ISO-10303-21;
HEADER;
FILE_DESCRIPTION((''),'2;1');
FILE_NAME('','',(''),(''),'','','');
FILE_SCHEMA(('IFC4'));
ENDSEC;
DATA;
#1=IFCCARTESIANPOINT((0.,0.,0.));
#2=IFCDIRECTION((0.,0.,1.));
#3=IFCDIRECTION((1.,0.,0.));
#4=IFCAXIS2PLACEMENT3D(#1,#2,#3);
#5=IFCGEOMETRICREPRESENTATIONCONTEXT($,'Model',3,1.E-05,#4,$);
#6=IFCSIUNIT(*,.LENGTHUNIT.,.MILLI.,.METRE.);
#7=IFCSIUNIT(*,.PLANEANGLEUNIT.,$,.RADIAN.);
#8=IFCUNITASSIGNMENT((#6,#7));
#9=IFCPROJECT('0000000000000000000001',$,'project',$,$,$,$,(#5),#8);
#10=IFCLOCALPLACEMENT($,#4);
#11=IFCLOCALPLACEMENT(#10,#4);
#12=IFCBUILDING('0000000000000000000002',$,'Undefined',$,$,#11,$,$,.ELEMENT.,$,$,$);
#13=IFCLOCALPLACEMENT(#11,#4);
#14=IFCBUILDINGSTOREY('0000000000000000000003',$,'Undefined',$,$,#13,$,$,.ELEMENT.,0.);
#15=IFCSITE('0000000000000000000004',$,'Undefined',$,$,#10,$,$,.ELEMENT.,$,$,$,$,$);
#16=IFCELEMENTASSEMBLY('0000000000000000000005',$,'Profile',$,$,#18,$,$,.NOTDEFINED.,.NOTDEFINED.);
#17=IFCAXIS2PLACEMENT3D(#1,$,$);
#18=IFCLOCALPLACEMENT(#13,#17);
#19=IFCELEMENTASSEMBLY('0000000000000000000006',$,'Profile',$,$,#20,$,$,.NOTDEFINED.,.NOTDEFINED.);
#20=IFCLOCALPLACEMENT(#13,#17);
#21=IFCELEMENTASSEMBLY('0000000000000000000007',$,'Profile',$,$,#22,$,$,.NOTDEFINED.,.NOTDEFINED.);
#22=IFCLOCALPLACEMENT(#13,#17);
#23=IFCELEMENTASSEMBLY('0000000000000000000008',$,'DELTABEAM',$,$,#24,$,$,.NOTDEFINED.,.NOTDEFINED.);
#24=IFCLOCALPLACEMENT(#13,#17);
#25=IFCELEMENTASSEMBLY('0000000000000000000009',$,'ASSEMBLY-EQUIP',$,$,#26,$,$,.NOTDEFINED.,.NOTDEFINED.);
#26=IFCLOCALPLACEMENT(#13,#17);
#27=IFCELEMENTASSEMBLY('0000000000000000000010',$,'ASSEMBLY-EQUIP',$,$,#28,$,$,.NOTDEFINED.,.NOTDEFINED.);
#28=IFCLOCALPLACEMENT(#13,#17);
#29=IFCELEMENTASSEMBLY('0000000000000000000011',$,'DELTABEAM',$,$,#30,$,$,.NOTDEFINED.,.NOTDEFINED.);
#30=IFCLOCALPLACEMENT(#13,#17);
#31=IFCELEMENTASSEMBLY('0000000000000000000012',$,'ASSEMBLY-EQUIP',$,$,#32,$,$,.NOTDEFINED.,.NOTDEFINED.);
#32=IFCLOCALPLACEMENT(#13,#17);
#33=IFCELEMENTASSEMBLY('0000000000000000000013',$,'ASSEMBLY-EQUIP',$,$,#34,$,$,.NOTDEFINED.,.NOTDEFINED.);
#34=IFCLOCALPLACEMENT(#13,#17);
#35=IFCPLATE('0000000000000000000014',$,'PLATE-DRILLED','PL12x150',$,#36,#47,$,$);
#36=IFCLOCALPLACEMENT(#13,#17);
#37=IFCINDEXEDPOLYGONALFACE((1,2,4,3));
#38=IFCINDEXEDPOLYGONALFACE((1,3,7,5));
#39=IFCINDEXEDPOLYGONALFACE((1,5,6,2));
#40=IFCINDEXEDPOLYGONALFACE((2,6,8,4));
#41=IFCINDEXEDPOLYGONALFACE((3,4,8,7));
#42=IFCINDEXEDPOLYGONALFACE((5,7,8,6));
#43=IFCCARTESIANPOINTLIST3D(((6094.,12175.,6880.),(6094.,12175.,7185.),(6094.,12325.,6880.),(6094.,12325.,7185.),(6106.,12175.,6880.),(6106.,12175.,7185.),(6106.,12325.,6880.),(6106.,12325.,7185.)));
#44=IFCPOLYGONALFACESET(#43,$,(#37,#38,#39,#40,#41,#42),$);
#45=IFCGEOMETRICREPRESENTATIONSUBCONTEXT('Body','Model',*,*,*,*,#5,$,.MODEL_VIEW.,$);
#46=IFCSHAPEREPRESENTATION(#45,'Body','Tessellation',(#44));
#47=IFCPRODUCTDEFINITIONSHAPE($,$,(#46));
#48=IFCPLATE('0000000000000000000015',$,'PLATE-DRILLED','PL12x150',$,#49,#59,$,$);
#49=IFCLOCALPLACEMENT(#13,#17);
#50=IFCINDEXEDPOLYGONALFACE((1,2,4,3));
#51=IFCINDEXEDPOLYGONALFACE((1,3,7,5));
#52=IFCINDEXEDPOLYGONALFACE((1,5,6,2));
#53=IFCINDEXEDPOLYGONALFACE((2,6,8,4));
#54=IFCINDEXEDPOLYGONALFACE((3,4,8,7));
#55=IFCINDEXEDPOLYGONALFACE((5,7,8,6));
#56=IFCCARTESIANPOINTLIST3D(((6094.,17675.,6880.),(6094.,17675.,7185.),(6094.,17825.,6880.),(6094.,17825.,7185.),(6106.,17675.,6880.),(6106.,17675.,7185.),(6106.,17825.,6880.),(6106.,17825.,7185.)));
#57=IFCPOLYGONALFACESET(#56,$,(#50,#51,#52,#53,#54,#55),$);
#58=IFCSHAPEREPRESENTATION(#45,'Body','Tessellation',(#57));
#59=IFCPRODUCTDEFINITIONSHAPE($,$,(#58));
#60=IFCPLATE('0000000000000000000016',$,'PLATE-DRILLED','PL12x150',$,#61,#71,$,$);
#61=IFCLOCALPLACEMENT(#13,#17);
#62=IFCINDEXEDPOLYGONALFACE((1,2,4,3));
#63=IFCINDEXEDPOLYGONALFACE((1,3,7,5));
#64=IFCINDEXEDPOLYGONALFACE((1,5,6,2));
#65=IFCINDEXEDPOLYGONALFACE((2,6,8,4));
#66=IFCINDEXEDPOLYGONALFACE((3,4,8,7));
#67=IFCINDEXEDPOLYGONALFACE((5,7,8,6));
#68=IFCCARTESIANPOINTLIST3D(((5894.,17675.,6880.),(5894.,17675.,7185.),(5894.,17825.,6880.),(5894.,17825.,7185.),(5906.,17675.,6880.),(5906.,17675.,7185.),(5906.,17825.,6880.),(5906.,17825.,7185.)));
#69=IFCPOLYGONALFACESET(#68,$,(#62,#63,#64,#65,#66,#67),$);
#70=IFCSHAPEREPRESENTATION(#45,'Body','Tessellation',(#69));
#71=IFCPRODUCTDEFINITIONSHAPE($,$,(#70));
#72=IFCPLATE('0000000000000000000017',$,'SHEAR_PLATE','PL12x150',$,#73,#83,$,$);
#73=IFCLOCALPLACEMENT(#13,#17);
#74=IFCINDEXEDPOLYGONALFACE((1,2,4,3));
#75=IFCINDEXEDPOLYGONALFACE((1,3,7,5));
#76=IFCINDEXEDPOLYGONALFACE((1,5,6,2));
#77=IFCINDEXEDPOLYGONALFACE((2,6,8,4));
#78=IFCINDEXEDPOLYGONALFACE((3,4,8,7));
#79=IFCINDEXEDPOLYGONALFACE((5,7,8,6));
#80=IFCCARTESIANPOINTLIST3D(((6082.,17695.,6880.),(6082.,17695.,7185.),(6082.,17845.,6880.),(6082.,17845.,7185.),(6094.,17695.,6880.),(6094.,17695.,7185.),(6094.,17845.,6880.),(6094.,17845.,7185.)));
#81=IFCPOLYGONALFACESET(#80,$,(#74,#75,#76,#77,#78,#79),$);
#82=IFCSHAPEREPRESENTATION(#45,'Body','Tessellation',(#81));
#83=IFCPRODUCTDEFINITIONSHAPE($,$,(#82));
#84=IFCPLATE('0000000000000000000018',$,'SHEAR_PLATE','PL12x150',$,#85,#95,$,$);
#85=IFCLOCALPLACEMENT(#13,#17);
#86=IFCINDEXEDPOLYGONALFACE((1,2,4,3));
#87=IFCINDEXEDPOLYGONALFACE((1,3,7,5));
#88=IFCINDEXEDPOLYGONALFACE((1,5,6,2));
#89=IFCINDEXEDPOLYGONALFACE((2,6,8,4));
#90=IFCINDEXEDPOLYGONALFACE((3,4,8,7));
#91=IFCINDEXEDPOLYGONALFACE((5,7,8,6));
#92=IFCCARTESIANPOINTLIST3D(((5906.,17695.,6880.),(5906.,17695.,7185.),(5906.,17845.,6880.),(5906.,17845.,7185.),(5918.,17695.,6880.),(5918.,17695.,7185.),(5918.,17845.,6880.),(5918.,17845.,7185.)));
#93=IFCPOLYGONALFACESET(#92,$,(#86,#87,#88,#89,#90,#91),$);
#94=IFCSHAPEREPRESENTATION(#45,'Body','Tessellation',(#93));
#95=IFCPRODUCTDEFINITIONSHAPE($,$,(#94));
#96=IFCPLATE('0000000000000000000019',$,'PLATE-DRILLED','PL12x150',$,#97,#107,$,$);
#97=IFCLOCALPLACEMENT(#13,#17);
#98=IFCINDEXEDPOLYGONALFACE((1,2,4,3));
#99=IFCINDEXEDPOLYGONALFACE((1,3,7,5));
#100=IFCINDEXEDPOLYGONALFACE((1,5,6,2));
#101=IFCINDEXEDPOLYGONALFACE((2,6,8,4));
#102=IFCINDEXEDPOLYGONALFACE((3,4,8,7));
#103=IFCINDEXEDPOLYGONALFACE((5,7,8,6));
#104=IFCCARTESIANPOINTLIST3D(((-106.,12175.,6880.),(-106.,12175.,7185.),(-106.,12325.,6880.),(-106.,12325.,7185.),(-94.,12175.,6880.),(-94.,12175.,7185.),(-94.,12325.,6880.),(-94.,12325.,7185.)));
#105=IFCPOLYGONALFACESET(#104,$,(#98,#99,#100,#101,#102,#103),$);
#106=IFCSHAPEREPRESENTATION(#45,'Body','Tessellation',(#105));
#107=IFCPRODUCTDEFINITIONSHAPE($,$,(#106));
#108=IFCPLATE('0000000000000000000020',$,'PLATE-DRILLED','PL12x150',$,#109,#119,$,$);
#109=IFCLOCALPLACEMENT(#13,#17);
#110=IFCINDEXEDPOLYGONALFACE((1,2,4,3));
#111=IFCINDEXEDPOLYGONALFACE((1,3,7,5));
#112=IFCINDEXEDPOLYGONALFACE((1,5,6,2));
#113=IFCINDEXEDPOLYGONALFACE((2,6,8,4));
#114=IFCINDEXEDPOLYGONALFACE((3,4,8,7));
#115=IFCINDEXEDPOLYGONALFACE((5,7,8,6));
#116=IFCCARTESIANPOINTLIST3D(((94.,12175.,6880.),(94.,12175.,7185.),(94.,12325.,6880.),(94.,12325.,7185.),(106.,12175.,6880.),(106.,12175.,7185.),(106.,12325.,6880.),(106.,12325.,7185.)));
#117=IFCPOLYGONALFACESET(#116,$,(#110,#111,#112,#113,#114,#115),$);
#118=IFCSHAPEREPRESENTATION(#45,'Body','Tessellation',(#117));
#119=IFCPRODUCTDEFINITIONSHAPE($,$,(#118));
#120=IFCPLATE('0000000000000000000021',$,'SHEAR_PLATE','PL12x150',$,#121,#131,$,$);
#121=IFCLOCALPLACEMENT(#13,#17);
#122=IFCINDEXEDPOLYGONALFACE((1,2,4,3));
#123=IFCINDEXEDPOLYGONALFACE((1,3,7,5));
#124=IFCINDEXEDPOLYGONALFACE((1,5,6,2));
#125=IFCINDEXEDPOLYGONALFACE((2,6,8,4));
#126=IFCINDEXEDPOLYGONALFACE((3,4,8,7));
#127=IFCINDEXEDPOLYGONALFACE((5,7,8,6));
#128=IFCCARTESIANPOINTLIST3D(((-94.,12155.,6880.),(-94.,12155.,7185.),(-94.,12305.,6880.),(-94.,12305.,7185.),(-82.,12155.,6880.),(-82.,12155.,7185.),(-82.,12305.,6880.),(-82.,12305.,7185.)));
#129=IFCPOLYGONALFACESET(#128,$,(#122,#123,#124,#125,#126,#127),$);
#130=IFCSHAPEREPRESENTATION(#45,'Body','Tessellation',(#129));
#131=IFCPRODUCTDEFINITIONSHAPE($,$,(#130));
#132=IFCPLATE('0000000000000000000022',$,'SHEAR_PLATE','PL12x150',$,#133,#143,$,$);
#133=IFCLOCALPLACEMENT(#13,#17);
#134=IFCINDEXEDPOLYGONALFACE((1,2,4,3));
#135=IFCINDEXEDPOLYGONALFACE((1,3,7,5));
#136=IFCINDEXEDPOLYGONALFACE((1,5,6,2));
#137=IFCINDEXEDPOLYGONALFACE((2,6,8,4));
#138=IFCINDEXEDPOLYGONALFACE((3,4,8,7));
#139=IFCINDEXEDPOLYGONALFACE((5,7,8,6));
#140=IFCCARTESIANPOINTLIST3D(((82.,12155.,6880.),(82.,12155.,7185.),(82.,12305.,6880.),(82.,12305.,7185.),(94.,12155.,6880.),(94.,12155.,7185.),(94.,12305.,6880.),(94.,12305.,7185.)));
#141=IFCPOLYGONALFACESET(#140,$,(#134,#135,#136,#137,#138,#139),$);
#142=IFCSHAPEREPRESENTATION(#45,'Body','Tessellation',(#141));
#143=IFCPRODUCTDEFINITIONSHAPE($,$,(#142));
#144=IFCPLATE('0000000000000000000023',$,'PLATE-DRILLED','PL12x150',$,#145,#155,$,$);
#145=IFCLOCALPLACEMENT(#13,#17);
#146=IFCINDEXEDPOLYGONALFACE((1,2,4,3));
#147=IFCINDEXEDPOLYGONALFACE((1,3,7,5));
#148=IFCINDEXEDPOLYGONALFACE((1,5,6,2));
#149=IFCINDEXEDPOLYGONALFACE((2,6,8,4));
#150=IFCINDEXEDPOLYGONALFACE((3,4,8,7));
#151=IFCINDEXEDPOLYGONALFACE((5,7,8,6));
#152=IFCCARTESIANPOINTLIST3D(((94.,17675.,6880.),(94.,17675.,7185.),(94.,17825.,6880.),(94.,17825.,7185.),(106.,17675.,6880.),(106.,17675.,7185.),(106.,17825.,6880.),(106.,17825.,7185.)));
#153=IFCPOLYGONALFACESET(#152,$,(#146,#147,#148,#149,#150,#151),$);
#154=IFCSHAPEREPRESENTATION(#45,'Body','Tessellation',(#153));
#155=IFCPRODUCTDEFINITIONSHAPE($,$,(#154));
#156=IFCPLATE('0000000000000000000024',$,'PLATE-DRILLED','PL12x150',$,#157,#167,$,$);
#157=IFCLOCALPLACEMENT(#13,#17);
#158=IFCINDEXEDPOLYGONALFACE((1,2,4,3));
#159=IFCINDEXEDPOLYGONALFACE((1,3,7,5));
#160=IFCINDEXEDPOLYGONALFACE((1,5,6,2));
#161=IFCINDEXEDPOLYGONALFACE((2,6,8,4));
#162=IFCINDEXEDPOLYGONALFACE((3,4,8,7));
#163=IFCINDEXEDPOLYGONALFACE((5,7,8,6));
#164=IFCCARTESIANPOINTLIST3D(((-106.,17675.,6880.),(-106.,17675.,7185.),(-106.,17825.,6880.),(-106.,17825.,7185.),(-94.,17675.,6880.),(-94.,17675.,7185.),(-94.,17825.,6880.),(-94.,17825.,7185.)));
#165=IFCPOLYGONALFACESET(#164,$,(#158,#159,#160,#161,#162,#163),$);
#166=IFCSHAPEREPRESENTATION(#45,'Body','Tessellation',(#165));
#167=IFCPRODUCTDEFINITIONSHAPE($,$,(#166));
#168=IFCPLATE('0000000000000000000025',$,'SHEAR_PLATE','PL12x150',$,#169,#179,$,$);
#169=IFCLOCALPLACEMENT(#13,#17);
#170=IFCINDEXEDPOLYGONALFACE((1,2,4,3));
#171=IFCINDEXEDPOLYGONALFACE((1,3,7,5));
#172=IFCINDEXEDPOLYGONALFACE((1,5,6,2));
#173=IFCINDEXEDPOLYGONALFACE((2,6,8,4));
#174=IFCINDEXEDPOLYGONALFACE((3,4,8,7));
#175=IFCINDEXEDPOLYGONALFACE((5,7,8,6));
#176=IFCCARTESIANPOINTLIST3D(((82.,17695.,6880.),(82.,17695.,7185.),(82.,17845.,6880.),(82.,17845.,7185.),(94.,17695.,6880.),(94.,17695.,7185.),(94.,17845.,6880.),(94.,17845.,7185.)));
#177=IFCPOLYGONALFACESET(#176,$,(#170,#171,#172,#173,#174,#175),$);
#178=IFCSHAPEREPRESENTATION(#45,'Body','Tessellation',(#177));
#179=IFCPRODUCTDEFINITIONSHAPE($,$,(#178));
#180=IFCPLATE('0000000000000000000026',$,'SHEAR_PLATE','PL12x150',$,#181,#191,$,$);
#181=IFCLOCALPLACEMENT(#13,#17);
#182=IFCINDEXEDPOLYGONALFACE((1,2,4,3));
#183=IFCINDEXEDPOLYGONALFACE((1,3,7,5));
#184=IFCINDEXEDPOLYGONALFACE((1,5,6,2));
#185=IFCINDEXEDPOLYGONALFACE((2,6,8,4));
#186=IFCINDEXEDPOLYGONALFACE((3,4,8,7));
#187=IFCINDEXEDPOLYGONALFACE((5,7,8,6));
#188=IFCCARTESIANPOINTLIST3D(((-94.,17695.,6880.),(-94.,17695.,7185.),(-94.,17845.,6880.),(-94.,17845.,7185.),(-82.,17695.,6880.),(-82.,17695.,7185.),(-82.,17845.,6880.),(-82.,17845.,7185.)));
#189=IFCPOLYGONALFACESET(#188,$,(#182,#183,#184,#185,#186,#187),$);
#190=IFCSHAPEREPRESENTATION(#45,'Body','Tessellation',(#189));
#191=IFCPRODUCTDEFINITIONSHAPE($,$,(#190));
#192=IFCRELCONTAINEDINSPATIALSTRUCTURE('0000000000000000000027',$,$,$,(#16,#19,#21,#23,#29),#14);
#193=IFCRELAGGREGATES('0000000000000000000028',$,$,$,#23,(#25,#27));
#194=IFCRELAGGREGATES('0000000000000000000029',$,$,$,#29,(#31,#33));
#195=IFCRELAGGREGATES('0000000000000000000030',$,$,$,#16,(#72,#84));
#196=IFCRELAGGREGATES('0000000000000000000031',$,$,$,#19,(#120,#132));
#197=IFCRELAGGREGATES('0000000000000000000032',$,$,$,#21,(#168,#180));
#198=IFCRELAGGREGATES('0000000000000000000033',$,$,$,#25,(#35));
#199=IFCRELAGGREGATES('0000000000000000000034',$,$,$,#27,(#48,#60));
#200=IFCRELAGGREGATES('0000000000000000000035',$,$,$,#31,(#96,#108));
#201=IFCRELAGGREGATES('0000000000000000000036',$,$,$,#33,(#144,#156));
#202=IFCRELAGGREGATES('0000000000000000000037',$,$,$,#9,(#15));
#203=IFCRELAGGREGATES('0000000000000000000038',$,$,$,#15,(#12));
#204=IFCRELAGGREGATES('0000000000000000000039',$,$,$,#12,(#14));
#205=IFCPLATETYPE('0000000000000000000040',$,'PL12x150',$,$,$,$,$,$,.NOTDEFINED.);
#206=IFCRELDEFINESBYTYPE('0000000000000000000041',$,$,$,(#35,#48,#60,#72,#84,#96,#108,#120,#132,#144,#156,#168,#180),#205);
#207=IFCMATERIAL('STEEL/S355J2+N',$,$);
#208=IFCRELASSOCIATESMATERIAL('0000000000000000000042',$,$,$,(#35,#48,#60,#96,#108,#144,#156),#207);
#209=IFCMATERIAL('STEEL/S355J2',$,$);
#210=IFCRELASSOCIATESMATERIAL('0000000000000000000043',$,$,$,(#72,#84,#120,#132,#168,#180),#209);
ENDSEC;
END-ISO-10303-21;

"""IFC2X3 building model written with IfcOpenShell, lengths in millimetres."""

from ifc_helpers import new_model, si_unit, frame, origin_with_axes, place, context, subcontext, project, spatial, polyline, outline, extrude, material, type_object, element, aggregate, save


model = new_model("IFC2X3")

# Units and contexts
model_context = context("Model", 3, precision=1e-05, world=origin_with_axes())
body_context = subcontext(model_context, "Body", "Model", "MODEL_VIEW")
ifc_project = project(units=[si_unit("LENGTHUNIT", "METRE", prefix="MILLI"), si_unit("PLANEANGLEUNIT", "RADIAN")], contexts=[model_context])

# Site, building, storey
site_placement = place(None, origin_with_axes())
site = spatial("IfcSite", under=ifc_project, at=site_placement, Name="Undefined", CompositionType="ELEMENT")
building_placement = place(site_placement, origin_with_axes())
building = spatial("IfcBuilding", under=site, at=building_placement, Name="Undefined", CompositionType="ELEMENT")
storey_placement = place(building_placement, origin_with_axes())
storey = spatial("IfcBuildingStorey", under=building, at=storey_placement, Name="Undefined", CompositionType="ELEMENT", Elevation=0.0)

# Element assemblies
ifc_material_1 = material(Name="STEEL/S355J2")
assembly_1_placement = place(storey_placement, origin_with_axes())
assembly_1 = element("IfcElementAssembly", 1, at=assembly_1_placement, inside=storey, Name="Profile", AssemblyPlace="NOTDEFINED", PredefinedType="NOTDEFINED")
assembly_2_placement = place(storey_placement, origin_with_axes())
assembly_2 = element("IfcElementAssembly", 2, at=assembly_2_placement, inside=storey, Name="Profile", AssemblyPlace="NOTDEFINED", PredefinedType="NOTDEFINED")
assembly_3_placement = place(storey_placement, origin_with_axes())
assembly_3 = element("IfcElementAssembly", 3, at=assembly_3_placement, inside=storey, Name="Profile", AssemblyPlace="NOTDEFINED", PredefinedType="NOTDEFINED")

# Element assemblies
assembly_4_placement = place(storey_placement, origin_with_axes())
assembly_4 = element("IfcElementAssembly", 4, at=assembly_4_placement, inside=storey, Name="DELTABEAM", AssemblyPlace="NOTDEFINED", PredefinedType="NOTDEFINED")
assembly_5_placement = place(assembly_4_placement, origin_with_axes())
assembly_5 = element("IfcElementAssembly", 5, at=assembly_5_placement, Name="ASSEMBLY-EQUIP", AssemblyPlace="NOTDEFINED", PredefinedType="NOTDEFINED")
ifc_material_2 = material(Name="STEEL/S355J2+N")
assembly_6_placement = place(assembly_4_placement, origin_with_axes())
assembly_6 = element("IfcElementAssembly", 6, at=assembly_6_placement, Name="ASSEMBLY-EQUIP", AssemblyPlace="NOTDEFINED", PredefinedType="NOTDEFINED")
aggregate(assembly_4, [assembly_5, assembly_6])
assembly_7_placement = place(storey_placement, origin_with_axes())
assembly_7 = element("IfcElementAssembly", 7, at=assembly_7_placement, inside=storey, Name="DELTABEAM", AssemblyPlace="NOTDEFINED", PredefinedType="NOTDEFINED")
assembly_8_placement = place(assembly_7_placement, origin_with_axes())
assembly_8 = element("IfcElementAssembly", 8, at=assembly_8_placement, Name="ASSEMBLY-EQUIP", AssemblyPlace="NOTDEFINED", PredefinedType="NOTDEFINED")
assembly_9_placement = place(assembly_7_placement, origin_with_axes())
assembly_9 = element("IfcElementAssembly", 9, at=assembly_9_placement, Name="ASSEMBLY-EQUIP", AssemblyPlace="NOTDEFINED", PredefinedType="NOTDEFINED")
aggregate(assembly_7, [assembly_8, assembly_9])

# Plates
plate_type_1 = type_object("IfcPlateType", Name="PL12x150", PredefinedType="NOTDEFINED")
plate_1_placement = place(assembly_5_placement, frame((6100.0, 12325.0, 7185.0), z_axis=(1.0, 0.0, 0.0), x_axis=(0.0, -1.0, 0.0)))
plate_1 = element("IfcPlate", 10, at=plate_1_placement, type_object=plate_type_1, material=ifc_material_2, Name="PLATE-DRILLED", Description="PL12x150", context=body_context, shape_type="SweptSolid", body=[
    extrude(outline(polyline([(0.0, 0.0), (150.0, 0.0), (150.0, 0.0), (150.0, 305.0), (150.0, 305.0), (0.0, 305.0), (0.0, 305.0), (0.0, 0.0)])), frame((0.0, 0.0, -6.0), z_axis=(0.0, 0.0, 1.0), x_axis=(1.0, 0.0, 0.0)), (0.0, 0.0, 1.0), 12.0),
])
plate_2_placement = place(assembly_6_placement, frame((6100.0, 17675.0, 7185.0), z_axis=(-1.0, 0.0, 0.0), x_axis=(0.0, 1.0, 0.0)))
plate_2 = element("IfcPlate", 11, at=plate_2_placement, type_object=plate_type_1, material=ifc_material_2, Name="PLATE-DRILLED", Description="PL12x150", context=body_context, shape_type="SweptSolid", body=[
    extrude(outline(polyline([(0.0, 0.0), (150.0, 0.0), (150.0, 0.0), (150.0, 305.0), (150.0, 305.0), (0.0, 305.0), (0.0, 305.0), (0.0, 0.0)])), frame((0.0, 0.0, -6.0), z_axis=(0.0, 0.0, 1.0), x_axis=(1.0, 0.0, 0.0)), (0.0, 0.0, 1.0), 12.0),
])
plate_3_placement = place(assembly_6_placement, frame((5900.0, 17675.0, 7185.0), z_axis=(-1.0, 0.0, 0.0), x_axis=(0.0, 1.0, 0.0)))
plate_3 = element("IfcPlate", 12, at=plate_3_placement, type_object=plate_type_1, material=ifc_material_2, Name="PLATE-DRILLED", Description="PL12x150", context=body_context, shape_type="SweptSolid", body=[
    extrude(outline(polyline([(0.0, 0.0), (150.0, 0.0), (150.0, 0.0), (150.0, 305.0), (150.0, 305.0), (0.0, 305.0), (0.0, 305.0), (0.0, 0.0)])), frame((0.0, 0.0, -6.0), z_axis=(0.0, 0.0, 1.0), x_axis=(1.0, 0.0, 0.0)), (0.0, 0.0, 1.0), 12.0),
])
plate_4_placement = place(assembly_1_placement, frame((6088.0, 17845.0, 7185.0), z_axis=(1.0, 0.0, 0.0), x_axis=(0.0, -1.0, 0.0)))
plate_4 = element("IfcPlate", 13, at=plate_4_placement, type_object=plate_type_1, material=ifc_material_1, Name="SHEAR_PLATE", Description="PL12x150", context=body_context, shape_type="SweptSolid", body=[
    extrude(outline(polyline([(0.0, 0.0), (150.0, 0.0), (150.0, 0.0), (150.0, 305.0), (150.0, 305.0), (0.0, 305.0), (0.0, 305.0), (0.0, 0.0)])), frame((0.0, 0.0, -6.0), z_axis=(0.0, 0.0, 1.0), x_axis=(1.0, 0.0, 0.0)), (0.0, 0.0, 1.0), 12.0),
])
plate_5_placement = place(assembly_1_placement, frame((5912.0, 17845.0, 7185.0), z_axis=(1.0, 0.0, 0.0), x_axis=(0.0, -1.0, 0.0)))
plate_5 = element("IfcPlate", 14, at=plate_5_placement, type_object=plate_type_1, material=ifc_material_1, Name="SHEAR_PLATE", Description="PL12x150", context=body_context, shape_type="SweptSolid", body=[
    extrude(outline(polyline([(0.0, 0.0), (150.0, 0.0), (150.0, 0.0), (150.0, 305.0), (150.0, 305.0), (0.0, 305.0), (0.0, 305.0), (0.0, 0.0)])), frame((0.0, 0.0, -6.0), z_axis=(0.0, 0.0, 1.0), x_axis=(1.0, 0.0, 0.0)), (0.0, 0.0, 1.0), 12.0),
])
aggregate(assembly_1, [plate_4, plate_5])
plate_6_placement = place(assembly_8_placement, frame((-100.0, 12325.0, 7185.0), z_axis=(1.0, 0.0, 0.0), x_axis=(0.0, -1.0, 0.0)))
plate_6 = element("IfcPlate", 15, at=plate_6_placement, type_object=plate_type_1, material=ifc_material_2, Name="PLATE-DRILLED", Description="PL12x150", context=body_context, shape_type="SweptSolid", body=[
    extrude(outline(polyline([(0.0, 0.0), (150.0, 0.0), (150.0, 0.0), (150.0, 305.0), (150.0, 305.0), (0.0, 305.0), (0.0, 305.0), (0.0, 0.0)])), frame((0.0, 0.0, -6.0), z_axis=(0.0, 0.0, 1.0), x_axis=(1.0, 0.0, 0.0)), (0.0, 0.0, 1.0), 12.0),
])
plate_7_placement = place(assembly_8_placement, frame((100.0, 12325.0, 7185.0), z_axis=(1.0, 0.0, 0.0), x_axis=(0.0, -1.0, 0.0)))
plate_7 = element("IfcPlate", 16, at=plate_7_placement, type_object=plate_type_1, material=ifc_material_2, Name="PLATE-DRILLED", Description="PL12x150", context=body_context, shape_type="SweptSolid", body=[
    extrude(outline(polyline([(0.0, 0.0), (150.0, 0.0), (150.0, 0.0), (150.0, 305.0), (150.0, 305.0), (0.0, 305.0), (0.0, 305.0), (0.0, 0.0)])), frame((0.0, 0.0, -6.0), z_axis=(0.0, 0.0, 1.0), x_axis=(1.0, 0.0, 0.0)), (0.0, 0.0, 1.0), 12.0),
])
plate_8_placement = place(assembly_2_placement, frame((-88.0, 12155.0, 7185.0), z_axis=(-1.0, 0.0, 0.0), x_axis=(0.0, 1.0, 0.0)))
plate_8 = element("IfcPlate", 17, at=plate_8_placement, type_object=plate_type_1, material=ifc_material_1, Name="SHEAR_PLATE", Description="PL12x150", context=body_context, shape_type="SweptSolid", body=[
    extrude(outline(polyline([(0.0, 0.0), (150.0, 0.0), (150.0, 0.0), (150.0, 305.0), (150.0, 305.0), (0.0, 305.0), (0.0, 305.0), (0.0, 0.0)])), frame((0.0, 0.0, -6.0), z_axis=(0.0, 0.0, 1.0), x_axis=(1.0, 0.0, 0.0)), (0.0, 0.0, 1.0), 12.0),
])
plate_9_placement = place(assembly_2_placement, frame((88.0, 12155.0, 7185.0), z_axis=(-1.0, 0.0, 0.0), x_axis=(0.0, 1.0, 0.0)))
plate_9 = element("IfcPlate", 18, at=plate_9_placement, type_object=plate_type_1, material=ifc_material_1, Name="SHEAR_PLATE", Description="PL12x150", context=body_context, shape_type="SweptSolid", body=[
    extrude(outline(polyline([(0.0, 0.0), (150.0, 0.0), (150.0, 0.0), (150.0, 305.0), (150.0, 305.0), (0.0, 305.0), (0.0, 305.0), (0.0, 0.0)])), frame((0.0, 0.0, -6.0), z_axis=(0.0, 0.0, 1.0), x_axis=(1.0, 0.0, 0.0)), (0.0, 0.0, 1.0), 12.0),
])
aggregate(assembly_2, [plate_8, plate_9])
plate_10_placement = place(assembly_9_placement, frame((100.0, 17675.0, 7185.0), z_axis=(-1.0, 0.0, 0.0), x_axis=(0.0, 1.0, 0.0)))
plate_10 = element("IfcPlate", 19, at=plate_10_placement, type_object=plate_type_1, material=ifc_material_2, Name="PLATE-DRILLED", Description="PL12x150", context=body_context, shape_type="SweptSolid", body=[
    extrude(outline(polyline([(0.0, 0.0), (150.0, 0.0), (150.0, 0.0), (150.0, 305.0), (150.0, 305.0), (0.0, 305.0), (0.0, 305.0), (0.0, 0.0)])), frame((0.0, 0.0, -6.0), z_axis=(0.0, 0.0, 1.0), x_axis=(1.0, 0.0, 0.0)), (0.0, 0.0, 1.0), 12.0),
])
plate_11_placement = place(assembly_9_placement, frame((-100.0, 17675.0, 7185.0), z_axis=(-1.0, 0.0, 0.0), x_axis=(0.0, 1.0, 0.0)))
plate_11 = element("IfcPlate", 20, at=plate_11_placement, type_object=plate_type_1, material=ifc_material_2, Name="PLATE-DRILLED", Description="PL12x150", context=body_context, shape_type="SweptSolid", body=[
    extrude(outline(polyline([(0.0, 0.0), (150.0, 0.0), (150.0, 0.0), (150.0, 305.0), (150.0, 305.0), (0.0, 305.0), (0.0, 305.0), (0.0, 0.0)])), frame((0.0, 0.0, -6.0), z_axis=(0.0, 0.0, 1.0), x_axis=(1.0, 0.0, 0.0)), (0.0, 0.0, 1.0), 12.0),
])
plate_12_placement = place(assembly_3_placement, frame((88.0, 17845.0, 7185.0), z_axis=(1.0, 0.0, 0.0), x_axis=(0.0, -1.0, 0.0)))
plate_12 = element("IfcPlate", 21, at=plate_12_placement, type_object=plate_type_1, material=ifc_material_1, Name="SHEAR_PLATE", Description="PL12x150", context=body_context, shape_type="SweptSolid", body=[
    extrude(outline(polyline([(0.0, 0.0), (150.0, 0.0), (150.0, 0.0), (150.0, 305.0), (150.0, 305.0), (0.0, 305.0), (0.0, 305.0), (0.0, 0.0)])), frame((0.0, 0.0, -6.0), z_axis=(0.0, 0.0, 1.0), x_axis=(1.0, 0.0, 0.0)), (0.0, 0.0, 1.0), 12.0),
])
plate_13_placement = place(assembly_3_placement, frame((-88.0, 17845.0, 7185.0), z_axis=(1.0, 0.0, 0.0), x_axis=(0.0, -1.0, 0.0)))
plate_13 = element("IfcPlate", 22, at=plate_13_placement, type_object=plate_type_1, material=ifc_material_1, Name="SHEAR_PLATE", Description="PL12x150", context=body_context, shape_type="SweptSolid", body=[
    extrude(outline(polyline([(0.0, 0.0), (150.0, 0.0), (150.0, 0.0), (150.0, 305.0), (150.0, 305.0), (0.0, 305.0), (0.0, 305.0), (0.0, 0.0)])), frame((0.0, 0.0, -6.0), z_axis=(0.0, 0.0, 1.0), x_axis=(1.0, 0.0, 0.0)), (0.0, 0.0, 1.0), 12.0),
])
aggregate(assembly_3, [plate_12, plate_13])

aggregate(assembly_5, [plate_1])
aggregate(assembly_6, [plate_2, plate_3])
aggregate(assembly_8, [plate_6, plate_7])
aggregate(assembly_9, [plate_10, plate_11])

save(model, "model.ifc")
